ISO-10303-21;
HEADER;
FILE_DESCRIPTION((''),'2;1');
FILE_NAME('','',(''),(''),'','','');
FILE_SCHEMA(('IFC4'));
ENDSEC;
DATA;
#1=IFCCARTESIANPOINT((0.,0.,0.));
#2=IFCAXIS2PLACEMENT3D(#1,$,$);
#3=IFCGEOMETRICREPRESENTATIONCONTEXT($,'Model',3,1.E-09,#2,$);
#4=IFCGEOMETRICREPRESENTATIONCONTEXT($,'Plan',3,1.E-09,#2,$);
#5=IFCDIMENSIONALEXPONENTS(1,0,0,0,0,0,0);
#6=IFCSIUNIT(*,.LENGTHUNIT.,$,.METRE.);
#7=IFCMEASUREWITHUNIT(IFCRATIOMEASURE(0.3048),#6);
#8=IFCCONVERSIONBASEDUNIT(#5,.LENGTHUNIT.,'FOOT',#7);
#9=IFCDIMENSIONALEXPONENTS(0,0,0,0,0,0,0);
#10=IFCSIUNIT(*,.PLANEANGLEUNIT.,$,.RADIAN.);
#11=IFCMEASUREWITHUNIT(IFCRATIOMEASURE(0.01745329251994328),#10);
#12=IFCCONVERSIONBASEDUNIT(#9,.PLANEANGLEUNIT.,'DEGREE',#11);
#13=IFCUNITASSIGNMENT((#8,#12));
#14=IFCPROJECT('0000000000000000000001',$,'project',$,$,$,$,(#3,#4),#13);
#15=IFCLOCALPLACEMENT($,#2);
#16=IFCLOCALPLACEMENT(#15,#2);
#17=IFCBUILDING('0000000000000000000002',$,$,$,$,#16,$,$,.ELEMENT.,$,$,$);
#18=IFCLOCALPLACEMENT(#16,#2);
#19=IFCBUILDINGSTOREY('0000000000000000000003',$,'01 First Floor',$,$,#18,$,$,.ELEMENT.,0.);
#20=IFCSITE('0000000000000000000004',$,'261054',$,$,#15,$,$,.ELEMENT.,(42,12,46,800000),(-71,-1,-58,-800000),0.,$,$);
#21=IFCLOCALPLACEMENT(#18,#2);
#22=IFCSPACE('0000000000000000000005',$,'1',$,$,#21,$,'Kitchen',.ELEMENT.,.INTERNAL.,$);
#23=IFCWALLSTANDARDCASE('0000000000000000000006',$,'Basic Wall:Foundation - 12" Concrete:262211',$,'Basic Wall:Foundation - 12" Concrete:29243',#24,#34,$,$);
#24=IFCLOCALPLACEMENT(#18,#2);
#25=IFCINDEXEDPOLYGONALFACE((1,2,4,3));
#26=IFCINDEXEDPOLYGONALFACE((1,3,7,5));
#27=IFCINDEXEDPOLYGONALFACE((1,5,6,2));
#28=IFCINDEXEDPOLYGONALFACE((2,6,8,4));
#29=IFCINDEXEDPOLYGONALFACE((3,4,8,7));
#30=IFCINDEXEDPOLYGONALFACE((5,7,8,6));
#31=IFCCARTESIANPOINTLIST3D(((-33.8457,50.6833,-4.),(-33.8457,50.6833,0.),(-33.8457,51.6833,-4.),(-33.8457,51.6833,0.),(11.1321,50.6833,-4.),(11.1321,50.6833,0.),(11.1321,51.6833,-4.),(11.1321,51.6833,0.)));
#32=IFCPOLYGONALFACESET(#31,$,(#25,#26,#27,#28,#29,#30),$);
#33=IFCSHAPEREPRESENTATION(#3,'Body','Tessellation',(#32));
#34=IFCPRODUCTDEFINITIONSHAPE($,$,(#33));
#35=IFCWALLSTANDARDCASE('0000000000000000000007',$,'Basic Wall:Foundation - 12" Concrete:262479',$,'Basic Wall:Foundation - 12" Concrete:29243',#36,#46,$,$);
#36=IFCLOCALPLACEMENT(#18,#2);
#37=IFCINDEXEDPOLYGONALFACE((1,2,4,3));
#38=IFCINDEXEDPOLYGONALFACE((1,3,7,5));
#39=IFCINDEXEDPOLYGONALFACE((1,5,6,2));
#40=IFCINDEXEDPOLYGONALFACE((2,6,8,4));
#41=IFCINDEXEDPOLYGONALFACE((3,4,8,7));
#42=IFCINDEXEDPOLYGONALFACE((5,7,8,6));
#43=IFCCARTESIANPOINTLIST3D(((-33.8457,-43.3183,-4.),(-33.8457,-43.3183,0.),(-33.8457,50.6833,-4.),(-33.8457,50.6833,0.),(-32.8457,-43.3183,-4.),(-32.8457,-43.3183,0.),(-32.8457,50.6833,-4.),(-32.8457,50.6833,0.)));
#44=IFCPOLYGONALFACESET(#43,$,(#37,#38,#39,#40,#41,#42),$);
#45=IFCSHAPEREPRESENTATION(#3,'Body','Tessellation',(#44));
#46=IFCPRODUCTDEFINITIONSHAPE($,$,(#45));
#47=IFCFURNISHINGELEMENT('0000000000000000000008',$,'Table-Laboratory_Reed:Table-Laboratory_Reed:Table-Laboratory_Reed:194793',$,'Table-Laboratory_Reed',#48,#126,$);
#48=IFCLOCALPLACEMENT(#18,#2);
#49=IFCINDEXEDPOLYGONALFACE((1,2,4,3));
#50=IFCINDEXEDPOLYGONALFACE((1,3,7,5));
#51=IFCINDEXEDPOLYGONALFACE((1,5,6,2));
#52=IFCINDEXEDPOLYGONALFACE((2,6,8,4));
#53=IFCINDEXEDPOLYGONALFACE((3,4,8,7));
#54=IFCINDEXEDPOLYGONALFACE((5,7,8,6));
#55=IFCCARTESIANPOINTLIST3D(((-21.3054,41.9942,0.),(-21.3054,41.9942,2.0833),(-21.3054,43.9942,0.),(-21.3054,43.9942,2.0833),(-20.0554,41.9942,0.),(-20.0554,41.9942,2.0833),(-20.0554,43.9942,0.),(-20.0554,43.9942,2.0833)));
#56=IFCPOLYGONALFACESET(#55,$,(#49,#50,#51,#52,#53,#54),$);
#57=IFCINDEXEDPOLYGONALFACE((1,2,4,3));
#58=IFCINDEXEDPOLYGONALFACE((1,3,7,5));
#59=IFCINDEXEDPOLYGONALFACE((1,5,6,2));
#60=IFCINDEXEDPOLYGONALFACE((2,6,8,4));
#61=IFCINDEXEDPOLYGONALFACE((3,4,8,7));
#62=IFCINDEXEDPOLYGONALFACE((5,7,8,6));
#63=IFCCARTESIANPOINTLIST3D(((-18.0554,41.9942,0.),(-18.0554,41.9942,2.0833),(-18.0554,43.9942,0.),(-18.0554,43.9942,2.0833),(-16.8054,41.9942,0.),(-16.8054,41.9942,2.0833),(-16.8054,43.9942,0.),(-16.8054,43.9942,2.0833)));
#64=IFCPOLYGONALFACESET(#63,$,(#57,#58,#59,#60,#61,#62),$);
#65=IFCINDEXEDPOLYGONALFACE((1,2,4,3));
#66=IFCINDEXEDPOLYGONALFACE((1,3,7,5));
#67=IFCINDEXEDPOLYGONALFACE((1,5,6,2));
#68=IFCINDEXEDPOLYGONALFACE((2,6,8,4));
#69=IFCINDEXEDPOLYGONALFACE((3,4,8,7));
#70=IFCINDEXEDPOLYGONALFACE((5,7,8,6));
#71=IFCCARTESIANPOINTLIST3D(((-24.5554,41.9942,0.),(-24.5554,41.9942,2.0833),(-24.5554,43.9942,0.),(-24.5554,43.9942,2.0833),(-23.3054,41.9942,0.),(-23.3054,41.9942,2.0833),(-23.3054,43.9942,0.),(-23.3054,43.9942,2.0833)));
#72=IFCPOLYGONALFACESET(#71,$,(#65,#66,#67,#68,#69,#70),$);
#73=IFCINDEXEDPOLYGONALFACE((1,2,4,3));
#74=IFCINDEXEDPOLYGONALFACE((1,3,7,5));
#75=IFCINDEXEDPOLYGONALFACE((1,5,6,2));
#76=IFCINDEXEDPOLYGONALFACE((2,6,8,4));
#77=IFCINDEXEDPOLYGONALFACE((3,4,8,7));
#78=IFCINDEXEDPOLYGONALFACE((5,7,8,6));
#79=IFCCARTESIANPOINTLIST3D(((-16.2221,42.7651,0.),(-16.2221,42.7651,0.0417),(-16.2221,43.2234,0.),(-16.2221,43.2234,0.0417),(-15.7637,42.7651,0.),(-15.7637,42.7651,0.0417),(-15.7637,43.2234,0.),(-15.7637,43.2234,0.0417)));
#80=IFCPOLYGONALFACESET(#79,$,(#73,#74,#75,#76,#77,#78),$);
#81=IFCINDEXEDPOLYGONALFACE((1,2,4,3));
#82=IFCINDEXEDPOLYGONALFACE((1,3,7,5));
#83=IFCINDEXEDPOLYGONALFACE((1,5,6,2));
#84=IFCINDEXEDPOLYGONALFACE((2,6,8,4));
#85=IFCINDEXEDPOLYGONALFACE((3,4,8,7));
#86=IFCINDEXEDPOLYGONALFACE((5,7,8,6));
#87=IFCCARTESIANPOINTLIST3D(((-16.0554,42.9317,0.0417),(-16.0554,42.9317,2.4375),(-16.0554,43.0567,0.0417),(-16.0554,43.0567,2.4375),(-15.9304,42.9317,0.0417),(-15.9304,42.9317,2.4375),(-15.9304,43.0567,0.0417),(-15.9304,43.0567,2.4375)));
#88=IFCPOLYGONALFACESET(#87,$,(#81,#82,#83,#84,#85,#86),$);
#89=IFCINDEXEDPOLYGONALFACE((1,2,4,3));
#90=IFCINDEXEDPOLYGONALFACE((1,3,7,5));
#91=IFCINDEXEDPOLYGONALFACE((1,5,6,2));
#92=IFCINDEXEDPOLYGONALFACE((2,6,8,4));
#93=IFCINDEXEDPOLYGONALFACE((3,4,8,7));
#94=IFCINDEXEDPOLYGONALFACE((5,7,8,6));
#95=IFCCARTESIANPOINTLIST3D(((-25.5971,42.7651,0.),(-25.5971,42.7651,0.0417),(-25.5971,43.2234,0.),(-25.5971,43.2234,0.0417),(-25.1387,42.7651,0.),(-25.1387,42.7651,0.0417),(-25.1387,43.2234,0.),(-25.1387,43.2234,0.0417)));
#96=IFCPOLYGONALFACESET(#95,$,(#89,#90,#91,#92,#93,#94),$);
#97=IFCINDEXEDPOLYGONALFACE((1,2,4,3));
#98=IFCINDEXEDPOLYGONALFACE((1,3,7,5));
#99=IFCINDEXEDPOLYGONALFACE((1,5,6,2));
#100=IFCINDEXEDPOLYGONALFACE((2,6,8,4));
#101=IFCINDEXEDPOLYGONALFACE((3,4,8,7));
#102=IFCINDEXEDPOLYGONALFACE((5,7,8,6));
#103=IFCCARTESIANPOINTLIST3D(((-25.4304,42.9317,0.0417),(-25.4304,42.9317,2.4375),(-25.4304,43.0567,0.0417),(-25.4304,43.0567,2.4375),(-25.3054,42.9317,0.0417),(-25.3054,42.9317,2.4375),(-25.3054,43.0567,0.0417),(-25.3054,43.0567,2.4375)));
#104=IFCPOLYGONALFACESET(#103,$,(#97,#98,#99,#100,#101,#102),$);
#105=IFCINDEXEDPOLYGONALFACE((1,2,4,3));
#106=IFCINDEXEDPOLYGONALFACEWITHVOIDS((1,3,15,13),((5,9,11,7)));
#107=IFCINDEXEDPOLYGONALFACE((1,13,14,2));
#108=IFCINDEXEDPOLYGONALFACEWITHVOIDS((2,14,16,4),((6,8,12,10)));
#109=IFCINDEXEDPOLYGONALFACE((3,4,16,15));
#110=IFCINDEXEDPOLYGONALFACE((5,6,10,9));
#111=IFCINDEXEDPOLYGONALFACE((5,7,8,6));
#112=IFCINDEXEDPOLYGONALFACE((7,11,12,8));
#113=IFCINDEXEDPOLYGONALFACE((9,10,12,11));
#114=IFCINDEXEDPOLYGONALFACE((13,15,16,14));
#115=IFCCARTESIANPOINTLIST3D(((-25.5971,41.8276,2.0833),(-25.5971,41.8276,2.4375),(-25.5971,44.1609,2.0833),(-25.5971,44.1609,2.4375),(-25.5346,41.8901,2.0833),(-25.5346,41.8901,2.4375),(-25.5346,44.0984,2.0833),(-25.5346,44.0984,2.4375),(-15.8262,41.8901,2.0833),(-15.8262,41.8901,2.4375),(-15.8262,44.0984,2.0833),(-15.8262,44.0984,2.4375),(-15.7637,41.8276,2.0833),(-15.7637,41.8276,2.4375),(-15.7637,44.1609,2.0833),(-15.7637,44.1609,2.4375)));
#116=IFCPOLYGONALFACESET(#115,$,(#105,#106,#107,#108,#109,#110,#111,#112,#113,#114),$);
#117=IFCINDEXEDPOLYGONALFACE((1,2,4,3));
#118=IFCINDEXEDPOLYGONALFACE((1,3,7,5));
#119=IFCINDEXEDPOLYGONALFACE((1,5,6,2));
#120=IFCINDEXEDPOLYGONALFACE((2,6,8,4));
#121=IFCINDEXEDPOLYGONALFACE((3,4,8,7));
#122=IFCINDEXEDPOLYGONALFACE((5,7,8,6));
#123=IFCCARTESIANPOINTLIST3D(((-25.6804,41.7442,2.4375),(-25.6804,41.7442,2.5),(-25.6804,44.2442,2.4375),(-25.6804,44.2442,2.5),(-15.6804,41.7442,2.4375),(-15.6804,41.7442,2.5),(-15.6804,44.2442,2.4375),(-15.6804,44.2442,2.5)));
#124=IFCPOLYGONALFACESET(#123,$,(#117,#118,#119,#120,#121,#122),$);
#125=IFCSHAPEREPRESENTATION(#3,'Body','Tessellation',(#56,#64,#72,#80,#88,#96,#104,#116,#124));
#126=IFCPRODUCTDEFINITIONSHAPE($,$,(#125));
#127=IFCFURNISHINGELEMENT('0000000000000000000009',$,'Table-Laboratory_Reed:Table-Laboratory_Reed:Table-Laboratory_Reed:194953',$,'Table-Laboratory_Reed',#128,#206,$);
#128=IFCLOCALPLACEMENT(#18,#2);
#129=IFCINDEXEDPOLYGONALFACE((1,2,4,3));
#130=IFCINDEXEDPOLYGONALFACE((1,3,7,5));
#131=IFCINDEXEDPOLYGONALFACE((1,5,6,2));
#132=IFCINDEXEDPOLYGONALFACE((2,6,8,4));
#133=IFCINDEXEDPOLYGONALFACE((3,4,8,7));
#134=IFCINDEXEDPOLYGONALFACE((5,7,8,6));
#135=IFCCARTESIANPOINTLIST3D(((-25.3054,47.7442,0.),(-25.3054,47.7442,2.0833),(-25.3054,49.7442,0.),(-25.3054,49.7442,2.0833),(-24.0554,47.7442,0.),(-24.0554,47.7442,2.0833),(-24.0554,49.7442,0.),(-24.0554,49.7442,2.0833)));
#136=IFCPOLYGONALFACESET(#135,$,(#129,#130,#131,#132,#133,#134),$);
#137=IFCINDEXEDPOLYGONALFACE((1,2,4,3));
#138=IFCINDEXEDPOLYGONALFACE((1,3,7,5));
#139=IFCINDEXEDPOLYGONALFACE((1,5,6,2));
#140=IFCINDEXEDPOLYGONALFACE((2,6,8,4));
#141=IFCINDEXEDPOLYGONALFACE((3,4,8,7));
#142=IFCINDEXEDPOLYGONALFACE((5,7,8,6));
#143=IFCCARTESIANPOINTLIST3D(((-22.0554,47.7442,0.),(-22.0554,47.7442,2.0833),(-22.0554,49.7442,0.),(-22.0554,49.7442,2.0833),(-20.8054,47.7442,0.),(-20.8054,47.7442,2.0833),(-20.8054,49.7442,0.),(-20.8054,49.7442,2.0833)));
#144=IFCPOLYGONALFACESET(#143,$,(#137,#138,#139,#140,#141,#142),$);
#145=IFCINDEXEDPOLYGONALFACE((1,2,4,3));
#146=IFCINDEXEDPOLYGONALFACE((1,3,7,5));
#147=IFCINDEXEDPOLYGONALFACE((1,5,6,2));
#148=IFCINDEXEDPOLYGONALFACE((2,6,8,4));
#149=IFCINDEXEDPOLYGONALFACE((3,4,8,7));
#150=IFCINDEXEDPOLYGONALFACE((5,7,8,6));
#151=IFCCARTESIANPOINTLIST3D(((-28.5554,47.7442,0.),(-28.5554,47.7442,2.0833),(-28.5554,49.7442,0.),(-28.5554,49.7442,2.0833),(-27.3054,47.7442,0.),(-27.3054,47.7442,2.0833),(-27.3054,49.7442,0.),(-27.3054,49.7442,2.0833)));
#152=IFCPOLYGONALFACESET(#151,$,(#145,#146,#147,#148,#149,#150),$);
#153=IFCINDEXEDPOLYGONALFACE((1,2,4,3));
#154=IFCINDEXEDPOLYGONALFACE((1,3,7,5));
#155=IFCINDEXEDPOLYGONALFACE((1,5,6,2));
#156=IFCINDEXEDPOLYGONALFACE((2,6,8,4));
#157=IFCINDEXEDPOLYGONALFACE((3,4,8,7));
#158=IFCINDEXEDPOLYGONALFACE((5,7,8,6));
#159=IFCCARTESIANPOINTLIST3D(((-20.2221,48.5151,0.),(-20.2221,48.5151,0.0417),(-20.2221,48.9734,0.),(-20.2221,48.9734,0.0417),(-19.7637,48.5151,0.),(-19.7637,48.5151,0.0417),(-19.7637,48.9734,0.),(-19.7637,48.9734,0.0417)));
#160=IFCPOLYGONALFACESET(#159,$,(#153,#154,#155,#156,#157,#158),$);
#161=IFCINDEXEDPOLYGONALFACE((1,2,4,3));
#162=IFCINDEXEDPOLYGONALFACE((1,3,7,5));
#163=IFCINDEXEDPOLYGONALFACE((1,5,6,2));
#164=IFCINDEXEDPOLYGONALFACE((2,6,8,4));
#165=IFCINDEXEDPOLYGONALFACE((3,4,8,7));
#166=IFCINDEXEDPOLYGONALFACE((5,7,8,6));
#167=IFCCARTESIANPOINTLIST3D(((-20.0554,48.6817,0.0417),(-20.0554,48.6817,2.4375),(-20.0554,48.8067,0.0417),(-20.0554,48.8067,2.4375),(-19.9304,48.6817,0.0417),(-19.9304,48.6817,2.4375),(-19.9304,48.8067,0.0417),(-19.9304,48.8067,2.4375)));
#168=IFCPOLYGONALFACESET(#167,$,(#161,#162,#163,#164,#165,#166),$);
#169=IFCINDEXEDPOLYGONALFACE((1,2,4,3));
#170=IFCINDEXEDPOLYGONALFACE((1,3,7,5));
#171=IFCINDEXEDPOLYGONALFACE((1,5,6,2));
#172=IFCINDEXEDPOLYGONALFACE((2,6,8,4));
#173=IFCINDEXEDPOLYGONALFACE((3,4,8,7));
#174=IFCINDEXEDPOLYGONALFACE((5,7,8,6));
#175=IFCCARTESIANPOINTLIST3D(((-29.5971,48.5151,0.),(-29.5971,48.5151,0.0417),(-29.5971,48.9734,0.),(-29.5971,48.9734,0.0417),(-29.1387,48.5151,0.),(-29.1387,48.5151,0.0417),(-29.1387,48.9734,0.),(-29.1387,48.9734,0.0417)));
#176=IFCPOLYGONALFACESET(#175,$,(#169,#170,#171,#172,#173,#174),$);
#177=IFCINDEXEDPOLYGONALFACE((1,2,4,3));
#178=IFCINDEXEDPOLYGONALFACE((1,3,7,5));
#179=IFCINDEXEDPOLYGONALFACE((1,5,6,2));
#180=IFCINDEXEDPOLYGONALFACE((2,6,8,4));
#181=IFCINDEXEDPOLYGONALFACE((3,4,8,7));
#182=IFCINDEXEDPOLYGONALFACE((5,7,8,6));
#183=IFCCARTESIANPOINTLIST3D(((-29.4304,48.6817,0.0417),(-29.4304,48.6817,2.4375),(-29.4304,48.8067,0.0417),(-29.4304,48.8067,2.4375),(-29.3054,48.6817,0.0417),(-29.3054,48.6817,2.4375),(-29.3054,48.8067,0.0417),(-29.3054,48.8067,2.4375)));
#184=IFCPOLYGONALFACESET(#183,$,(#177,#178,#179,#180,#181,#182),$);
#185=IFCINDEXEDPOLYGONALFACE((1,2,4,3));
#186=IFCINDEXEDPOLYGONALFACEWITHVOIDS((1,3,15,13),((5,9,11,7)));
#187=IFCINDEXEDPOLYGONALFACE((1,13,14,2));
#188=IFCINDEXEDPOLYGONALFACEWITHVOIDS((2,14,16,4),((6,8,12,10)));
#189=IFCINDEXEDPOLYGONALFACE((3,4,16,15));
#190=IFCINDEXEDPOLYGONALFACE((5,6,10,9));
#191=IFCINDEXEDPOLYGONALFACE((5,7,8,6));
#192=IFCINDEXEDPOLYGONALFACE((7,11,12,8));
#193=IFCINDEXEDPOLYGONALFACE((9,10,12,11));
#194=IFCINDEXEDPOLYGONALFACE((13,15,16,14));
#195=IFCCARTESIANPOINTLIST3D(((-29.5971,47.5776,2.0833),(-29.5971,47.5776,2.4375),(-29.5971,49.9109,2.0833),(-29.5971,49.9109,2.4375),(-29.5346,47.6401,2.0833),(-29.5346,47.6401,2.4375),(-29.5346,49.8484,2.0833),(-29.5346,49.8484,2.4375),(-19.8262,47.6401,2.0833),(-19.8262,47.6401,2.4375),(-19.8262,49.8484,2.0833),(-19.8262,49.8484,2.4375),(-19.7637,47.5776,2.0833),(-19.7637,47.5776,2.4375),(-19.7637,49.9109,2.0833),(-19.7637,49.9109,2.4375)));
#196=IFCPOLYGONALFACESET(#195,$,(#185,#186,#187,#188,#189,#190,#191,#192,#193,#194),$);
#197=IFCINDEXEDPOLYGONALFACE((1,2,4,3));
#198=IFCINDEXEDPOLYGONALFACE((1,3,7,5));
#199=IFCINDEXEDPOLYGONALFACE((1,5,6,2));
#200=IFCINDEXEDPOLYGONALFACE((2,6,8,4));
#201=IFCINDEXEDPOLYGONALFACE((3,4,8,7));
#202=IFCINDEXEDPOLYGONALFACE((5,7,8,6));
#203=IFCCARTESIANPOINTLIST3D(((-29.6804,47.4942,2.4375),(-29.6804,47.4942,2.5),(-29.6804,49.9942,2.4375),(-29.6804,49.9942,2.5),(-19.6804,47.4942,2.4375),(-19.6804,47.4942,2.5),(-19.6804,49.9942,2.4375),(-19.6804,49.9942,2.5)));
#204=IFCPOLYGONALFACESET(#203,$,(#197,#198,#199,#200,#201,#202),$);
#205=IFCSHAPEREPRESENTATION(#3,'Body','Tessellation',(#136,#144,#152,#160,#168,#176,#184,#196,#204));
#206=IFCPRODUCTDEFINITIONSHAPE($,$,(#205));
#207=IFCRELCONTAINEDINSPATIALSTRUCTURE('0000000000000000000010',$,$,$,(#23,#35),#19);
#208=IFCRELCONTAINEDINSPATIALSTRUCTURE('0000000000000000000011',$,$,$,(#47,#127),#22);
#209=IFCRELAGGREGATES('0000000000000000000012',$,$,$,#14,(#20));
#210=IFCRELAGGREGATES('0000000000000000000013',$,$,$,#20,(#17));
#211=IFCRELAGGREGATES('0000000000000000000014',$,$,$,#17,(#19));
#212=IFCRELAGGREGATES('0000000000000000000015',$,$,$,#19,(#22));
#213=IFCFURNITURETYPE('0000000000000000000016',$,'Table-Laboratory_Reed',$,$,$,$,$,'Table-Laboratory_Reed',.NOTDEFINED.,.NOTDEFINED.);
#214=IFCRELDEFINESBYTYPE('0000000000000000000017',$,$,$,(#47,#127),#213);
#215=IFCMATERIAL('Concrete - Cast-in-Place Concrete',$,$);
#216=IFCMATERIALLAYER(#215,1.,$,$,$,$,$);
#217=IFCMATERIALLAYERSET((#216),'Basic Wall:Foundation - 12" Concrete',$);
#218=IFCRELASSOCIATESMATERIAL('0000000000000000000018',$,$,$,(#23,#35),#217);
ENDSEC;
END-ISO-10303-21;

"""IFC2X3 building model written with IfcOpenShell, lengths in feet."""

from ifc_helpers import new_model, entity, si_unit, converted_unit, frame, frame_2d, origin, origin_2d_with_axis, place, context, project, spatial, polyline, rectangle, outline, extrude, source, transform, mapped, material, layer, layer_set, layer_usage, type_object, type_shapes, element, save


model = new_model("IFC2X3")

# Units and contexts
model_context = context("Model", 3, precision=1e-09, world=origin())
plan_context = context("Plan", 3, precision=1e-09, world=origin())
ifc_project = project(units=[converted_unit("LENGTHUNIT", "FOOT", entity("IfcRatioMeasure", 0.3048), si_unit("LENGTHUNIT", "METRE"), dimensions=[1, 0, 0, 0, 0, 0, 0]), converted_unit("PLANEANGLEUNIT", "DEGREE", entity("IfcRatioMeasure", 0.01745329251994328), si_unit("PLANEANGLEUNIT", "RADIAN"), dimensions=[0, 0, 0, 0, 0, 0, 0])], contexts=[model_context, plan_context])

# Site, building, storey
site_placement = place(None, origin())
site = spatial("IfcSite", under=ifc_project, at=site_placement, Name="261054", CompositionType="ELEMENT", RefLatitude=(42, 12, 46, 800000), RefLongitude=(-71, -1, -58, -800000), RefElevation=0.0)
building_placement = place(site_placement, origin())
building = spatial("IfcBuilding", under=site, at=building_placement, CompositionType="ELEMENT")
storey_placement = place(building_placement, origin())
storey = spatial("IfcBuildingStorey", under=building, at=storey_placement, Name="01 First Floor", CompositionType="ELEMENT", Elevation=0.0)

# Walls
ifc_material_1 = material(Name="Concrete - Cast-in-Place Concrete")
ifc_layer_1 = layer(ifc_material_1, 1.0)
ifc_layer_set_1 = layer_set([ifc_layer_1], Name="Basic Wall:Foundation - 12\" Concrete")
ifc_layer_usage_1 = layer_usage(ifc_layer_set_1, "AXIS2", "NEGATIVE", 0.5)
wall_1_placement = place(storey_placement, frame((-33.8457, 51.1833, -4.0)))
element("IfcWallStandardCase", 1, at=wall_1_placement, inside=storey, material=ifc_layer_usage_1, Name="Basic Wall:Foundation - 12\" Concrete:262211", ObjectType="Basic Wall:Foundation - 12\" Concrete:29243", context=model_context, shape_type="SweptSolid", body=[
    extrude(rectangle(XDim=44.9778, YDim=1.0, at=frame_2d((22.4889, 0.0), x_axis=(-1.0, 0.0))), origin(), (0.0, 0.0, 1.0), 4.0),
])
ifc_layer_usage_2 = layer_usage(ifc_layer_set_1, "AXIS2", "NEGATIVE", 0.5)
wall_2_placement = place(storey_placement, frame((-33.3457, 50.6833, -4.0), z_axis=(0.0, 0.0, 1.0), x_axis=(0.0, -1.0, 0.0)))
element("IfcWallStandardCase", 2, at=wall_2_placement, inside=storey, material=ifc_layer_usage_2, Name="Basic Wall:Foundation - 12\" Concrete:262479", ObjectType="Basic Wall:Foundation - 12\" Concrete:29243", context=model_context, shape_type="SweptSolid", body=[
    extrude(rectangle(XDim=94.0015, YDim=1.0, at=frame_2d((47.0008, 0.0), x_axis=(-1.0, 0.0))), origin(), (0.0, 0.0, 1.0), 4.0),
])

# Shared definitions
space_1_placement = place(storey_placement, origin())
space_1 = spatial("IfcSpace", under=storey, at=space_1_placement, Name="1", LongName="Kitchen", CompositionType="ELEMENT", InteriorOrExteriorSpace="INTERNAL")

# Furnishing elements
furniture_type = type_object("IfcFurnitureType", Name="Table-Laboratory_Reed", ElementType="Table-Laboratory_Reed", AssemblyPlace="NOTDEFINED")
shared_shape_1 = source(origin(), model_context, "Body", "SweptSolid", [
    extrude(rectangle(XDim=1.25, YDim=2.0, at=origin_2d_with_axis()), frame((-0.3333, 0.0, 0.0), z_axis=(0.0, 0.0, 1.0), x_axis=(-1.0, 0.0, 0.0)), (0.0, 0.0, 1.0), 2.0833),
    extrude(rectangle(XDim=1.25, YDim=2.0, at=origin_2d_with_axis()), frame((2.9167, 0.0, 0.0), z_axis=(0.0, 0.0, 1.0), x_axis=(-1.0, 0.0, 0.0)), (0.0, 0.0, 1.0), 2.0833),
    extrude(rectangle(XDim=1.25, YDim=2.0, at=origin_2d_with_axis()), frame((-3.5833, 0.0, 0.0), z_axis=(0.0, 0.0, 1.0), x_axis=(-1.0, 0.0, 0.0)), (0.0, 0.0, 1.0), 2.0833),
    extrude(rectangle(XDim=0.4583, YDim=0.4583, at=origin_2d_with_axis()), frame((4.3542, 0.0, 0.0), z_axis=(0.0, 0.0, 1.0), x_axis=(-1.0, 0.0, 0.0)), (0.0, 0.0, 1.0), 0.0417),
    extrude(rectangle(XDim=0.125, YDim=0.125, at=origin_2d_with_axis()), frame((4.3542, 0.0, 0.0417), z_axis=(0.0, 0.0, 1.0), x_axis=(-1.0, 0.0, 0.0)), (0.0, 0.0, 1.0), 2.3958),
    extrude(rectangle(XDim=0.4583, YDim=0.4583, at=origin_2d_with_axis()), frame((-5.0208, 0.0, 0.0), z_axis=(0.0, 0.0, 1.0), x_axis=(-1.0, 0.0, 0.0)), (0.0, 0.0, 1.0), 0.0417),
    extrude(rectangle(XDim=0.125, YDim=0.125, at=origin_2d_with_axis()), frame((-5.0208, 0.0, 0.0417), z_axis=(0.0, 0.0, 1.0), x_axis=(-1.0, 0.0, 0.0)), (0.0, 0.0, 1.0), 2.3958),
    extrude(outline(polyline([(-4.9167, -1.1667), (4.9167, -1.1667), (4.9167, 1.1667), (-4.9167, 1.1667), (-4.9167, -1.1667)]), holes=[polyline([(-4.8542, -1.1042), (-4.8542, 1.1042), (4.8542, 1.1042), (4.8542, -1.1042), (-4.8542, -1.1042)])]), frame((-0.3333, 0.0, 2.0833), z_axis=(0.0, 0.0, 1.0), x_axis=(-1.0, 0.0, 0.0)), (0.0, 0.0, 1.0), 0.3542),
    extrude(rectangle(XDim=10.0, YDim=2.5, at=origin_2d_with_axis()), frame((-0.3333, 0.0, 2.4375), z_axis=(0.0, 0.0, 1.0), x_axis=(-1.0, 0.0, 0.0)), (0.0, 0.0, 1.0), 0.0625),
])
type_shapes(furniture_type, [shared_shape_1])
for number, where, name in (
    (3, (-20.3471, 42.9942, 0.0), "Table-Laboratory_Reed:Table-Laboratory_Reed:Table-Laboratory_Reed:194793"),
    (4, (-24.3471, 48.7442, 0.0), "Table-Laboratory_Reed:Table-Laboratory_Reed:Table-Laboratory_Reed:194953"),
):
    element("IfcFurnishingElement", number, at=place(space_1_placement, frame(where)), inside=space_1, type_object=furniture_type, Name=name, ObjectType="Table-Laboratory_Reed", context=model_context, shape_type="MappedRepresentation", body=[
        mapped(shared_shape_1, transform((0.0, 0.0, 0.0), scale=1.0)),
    ])

save(model, "model.ifc")
